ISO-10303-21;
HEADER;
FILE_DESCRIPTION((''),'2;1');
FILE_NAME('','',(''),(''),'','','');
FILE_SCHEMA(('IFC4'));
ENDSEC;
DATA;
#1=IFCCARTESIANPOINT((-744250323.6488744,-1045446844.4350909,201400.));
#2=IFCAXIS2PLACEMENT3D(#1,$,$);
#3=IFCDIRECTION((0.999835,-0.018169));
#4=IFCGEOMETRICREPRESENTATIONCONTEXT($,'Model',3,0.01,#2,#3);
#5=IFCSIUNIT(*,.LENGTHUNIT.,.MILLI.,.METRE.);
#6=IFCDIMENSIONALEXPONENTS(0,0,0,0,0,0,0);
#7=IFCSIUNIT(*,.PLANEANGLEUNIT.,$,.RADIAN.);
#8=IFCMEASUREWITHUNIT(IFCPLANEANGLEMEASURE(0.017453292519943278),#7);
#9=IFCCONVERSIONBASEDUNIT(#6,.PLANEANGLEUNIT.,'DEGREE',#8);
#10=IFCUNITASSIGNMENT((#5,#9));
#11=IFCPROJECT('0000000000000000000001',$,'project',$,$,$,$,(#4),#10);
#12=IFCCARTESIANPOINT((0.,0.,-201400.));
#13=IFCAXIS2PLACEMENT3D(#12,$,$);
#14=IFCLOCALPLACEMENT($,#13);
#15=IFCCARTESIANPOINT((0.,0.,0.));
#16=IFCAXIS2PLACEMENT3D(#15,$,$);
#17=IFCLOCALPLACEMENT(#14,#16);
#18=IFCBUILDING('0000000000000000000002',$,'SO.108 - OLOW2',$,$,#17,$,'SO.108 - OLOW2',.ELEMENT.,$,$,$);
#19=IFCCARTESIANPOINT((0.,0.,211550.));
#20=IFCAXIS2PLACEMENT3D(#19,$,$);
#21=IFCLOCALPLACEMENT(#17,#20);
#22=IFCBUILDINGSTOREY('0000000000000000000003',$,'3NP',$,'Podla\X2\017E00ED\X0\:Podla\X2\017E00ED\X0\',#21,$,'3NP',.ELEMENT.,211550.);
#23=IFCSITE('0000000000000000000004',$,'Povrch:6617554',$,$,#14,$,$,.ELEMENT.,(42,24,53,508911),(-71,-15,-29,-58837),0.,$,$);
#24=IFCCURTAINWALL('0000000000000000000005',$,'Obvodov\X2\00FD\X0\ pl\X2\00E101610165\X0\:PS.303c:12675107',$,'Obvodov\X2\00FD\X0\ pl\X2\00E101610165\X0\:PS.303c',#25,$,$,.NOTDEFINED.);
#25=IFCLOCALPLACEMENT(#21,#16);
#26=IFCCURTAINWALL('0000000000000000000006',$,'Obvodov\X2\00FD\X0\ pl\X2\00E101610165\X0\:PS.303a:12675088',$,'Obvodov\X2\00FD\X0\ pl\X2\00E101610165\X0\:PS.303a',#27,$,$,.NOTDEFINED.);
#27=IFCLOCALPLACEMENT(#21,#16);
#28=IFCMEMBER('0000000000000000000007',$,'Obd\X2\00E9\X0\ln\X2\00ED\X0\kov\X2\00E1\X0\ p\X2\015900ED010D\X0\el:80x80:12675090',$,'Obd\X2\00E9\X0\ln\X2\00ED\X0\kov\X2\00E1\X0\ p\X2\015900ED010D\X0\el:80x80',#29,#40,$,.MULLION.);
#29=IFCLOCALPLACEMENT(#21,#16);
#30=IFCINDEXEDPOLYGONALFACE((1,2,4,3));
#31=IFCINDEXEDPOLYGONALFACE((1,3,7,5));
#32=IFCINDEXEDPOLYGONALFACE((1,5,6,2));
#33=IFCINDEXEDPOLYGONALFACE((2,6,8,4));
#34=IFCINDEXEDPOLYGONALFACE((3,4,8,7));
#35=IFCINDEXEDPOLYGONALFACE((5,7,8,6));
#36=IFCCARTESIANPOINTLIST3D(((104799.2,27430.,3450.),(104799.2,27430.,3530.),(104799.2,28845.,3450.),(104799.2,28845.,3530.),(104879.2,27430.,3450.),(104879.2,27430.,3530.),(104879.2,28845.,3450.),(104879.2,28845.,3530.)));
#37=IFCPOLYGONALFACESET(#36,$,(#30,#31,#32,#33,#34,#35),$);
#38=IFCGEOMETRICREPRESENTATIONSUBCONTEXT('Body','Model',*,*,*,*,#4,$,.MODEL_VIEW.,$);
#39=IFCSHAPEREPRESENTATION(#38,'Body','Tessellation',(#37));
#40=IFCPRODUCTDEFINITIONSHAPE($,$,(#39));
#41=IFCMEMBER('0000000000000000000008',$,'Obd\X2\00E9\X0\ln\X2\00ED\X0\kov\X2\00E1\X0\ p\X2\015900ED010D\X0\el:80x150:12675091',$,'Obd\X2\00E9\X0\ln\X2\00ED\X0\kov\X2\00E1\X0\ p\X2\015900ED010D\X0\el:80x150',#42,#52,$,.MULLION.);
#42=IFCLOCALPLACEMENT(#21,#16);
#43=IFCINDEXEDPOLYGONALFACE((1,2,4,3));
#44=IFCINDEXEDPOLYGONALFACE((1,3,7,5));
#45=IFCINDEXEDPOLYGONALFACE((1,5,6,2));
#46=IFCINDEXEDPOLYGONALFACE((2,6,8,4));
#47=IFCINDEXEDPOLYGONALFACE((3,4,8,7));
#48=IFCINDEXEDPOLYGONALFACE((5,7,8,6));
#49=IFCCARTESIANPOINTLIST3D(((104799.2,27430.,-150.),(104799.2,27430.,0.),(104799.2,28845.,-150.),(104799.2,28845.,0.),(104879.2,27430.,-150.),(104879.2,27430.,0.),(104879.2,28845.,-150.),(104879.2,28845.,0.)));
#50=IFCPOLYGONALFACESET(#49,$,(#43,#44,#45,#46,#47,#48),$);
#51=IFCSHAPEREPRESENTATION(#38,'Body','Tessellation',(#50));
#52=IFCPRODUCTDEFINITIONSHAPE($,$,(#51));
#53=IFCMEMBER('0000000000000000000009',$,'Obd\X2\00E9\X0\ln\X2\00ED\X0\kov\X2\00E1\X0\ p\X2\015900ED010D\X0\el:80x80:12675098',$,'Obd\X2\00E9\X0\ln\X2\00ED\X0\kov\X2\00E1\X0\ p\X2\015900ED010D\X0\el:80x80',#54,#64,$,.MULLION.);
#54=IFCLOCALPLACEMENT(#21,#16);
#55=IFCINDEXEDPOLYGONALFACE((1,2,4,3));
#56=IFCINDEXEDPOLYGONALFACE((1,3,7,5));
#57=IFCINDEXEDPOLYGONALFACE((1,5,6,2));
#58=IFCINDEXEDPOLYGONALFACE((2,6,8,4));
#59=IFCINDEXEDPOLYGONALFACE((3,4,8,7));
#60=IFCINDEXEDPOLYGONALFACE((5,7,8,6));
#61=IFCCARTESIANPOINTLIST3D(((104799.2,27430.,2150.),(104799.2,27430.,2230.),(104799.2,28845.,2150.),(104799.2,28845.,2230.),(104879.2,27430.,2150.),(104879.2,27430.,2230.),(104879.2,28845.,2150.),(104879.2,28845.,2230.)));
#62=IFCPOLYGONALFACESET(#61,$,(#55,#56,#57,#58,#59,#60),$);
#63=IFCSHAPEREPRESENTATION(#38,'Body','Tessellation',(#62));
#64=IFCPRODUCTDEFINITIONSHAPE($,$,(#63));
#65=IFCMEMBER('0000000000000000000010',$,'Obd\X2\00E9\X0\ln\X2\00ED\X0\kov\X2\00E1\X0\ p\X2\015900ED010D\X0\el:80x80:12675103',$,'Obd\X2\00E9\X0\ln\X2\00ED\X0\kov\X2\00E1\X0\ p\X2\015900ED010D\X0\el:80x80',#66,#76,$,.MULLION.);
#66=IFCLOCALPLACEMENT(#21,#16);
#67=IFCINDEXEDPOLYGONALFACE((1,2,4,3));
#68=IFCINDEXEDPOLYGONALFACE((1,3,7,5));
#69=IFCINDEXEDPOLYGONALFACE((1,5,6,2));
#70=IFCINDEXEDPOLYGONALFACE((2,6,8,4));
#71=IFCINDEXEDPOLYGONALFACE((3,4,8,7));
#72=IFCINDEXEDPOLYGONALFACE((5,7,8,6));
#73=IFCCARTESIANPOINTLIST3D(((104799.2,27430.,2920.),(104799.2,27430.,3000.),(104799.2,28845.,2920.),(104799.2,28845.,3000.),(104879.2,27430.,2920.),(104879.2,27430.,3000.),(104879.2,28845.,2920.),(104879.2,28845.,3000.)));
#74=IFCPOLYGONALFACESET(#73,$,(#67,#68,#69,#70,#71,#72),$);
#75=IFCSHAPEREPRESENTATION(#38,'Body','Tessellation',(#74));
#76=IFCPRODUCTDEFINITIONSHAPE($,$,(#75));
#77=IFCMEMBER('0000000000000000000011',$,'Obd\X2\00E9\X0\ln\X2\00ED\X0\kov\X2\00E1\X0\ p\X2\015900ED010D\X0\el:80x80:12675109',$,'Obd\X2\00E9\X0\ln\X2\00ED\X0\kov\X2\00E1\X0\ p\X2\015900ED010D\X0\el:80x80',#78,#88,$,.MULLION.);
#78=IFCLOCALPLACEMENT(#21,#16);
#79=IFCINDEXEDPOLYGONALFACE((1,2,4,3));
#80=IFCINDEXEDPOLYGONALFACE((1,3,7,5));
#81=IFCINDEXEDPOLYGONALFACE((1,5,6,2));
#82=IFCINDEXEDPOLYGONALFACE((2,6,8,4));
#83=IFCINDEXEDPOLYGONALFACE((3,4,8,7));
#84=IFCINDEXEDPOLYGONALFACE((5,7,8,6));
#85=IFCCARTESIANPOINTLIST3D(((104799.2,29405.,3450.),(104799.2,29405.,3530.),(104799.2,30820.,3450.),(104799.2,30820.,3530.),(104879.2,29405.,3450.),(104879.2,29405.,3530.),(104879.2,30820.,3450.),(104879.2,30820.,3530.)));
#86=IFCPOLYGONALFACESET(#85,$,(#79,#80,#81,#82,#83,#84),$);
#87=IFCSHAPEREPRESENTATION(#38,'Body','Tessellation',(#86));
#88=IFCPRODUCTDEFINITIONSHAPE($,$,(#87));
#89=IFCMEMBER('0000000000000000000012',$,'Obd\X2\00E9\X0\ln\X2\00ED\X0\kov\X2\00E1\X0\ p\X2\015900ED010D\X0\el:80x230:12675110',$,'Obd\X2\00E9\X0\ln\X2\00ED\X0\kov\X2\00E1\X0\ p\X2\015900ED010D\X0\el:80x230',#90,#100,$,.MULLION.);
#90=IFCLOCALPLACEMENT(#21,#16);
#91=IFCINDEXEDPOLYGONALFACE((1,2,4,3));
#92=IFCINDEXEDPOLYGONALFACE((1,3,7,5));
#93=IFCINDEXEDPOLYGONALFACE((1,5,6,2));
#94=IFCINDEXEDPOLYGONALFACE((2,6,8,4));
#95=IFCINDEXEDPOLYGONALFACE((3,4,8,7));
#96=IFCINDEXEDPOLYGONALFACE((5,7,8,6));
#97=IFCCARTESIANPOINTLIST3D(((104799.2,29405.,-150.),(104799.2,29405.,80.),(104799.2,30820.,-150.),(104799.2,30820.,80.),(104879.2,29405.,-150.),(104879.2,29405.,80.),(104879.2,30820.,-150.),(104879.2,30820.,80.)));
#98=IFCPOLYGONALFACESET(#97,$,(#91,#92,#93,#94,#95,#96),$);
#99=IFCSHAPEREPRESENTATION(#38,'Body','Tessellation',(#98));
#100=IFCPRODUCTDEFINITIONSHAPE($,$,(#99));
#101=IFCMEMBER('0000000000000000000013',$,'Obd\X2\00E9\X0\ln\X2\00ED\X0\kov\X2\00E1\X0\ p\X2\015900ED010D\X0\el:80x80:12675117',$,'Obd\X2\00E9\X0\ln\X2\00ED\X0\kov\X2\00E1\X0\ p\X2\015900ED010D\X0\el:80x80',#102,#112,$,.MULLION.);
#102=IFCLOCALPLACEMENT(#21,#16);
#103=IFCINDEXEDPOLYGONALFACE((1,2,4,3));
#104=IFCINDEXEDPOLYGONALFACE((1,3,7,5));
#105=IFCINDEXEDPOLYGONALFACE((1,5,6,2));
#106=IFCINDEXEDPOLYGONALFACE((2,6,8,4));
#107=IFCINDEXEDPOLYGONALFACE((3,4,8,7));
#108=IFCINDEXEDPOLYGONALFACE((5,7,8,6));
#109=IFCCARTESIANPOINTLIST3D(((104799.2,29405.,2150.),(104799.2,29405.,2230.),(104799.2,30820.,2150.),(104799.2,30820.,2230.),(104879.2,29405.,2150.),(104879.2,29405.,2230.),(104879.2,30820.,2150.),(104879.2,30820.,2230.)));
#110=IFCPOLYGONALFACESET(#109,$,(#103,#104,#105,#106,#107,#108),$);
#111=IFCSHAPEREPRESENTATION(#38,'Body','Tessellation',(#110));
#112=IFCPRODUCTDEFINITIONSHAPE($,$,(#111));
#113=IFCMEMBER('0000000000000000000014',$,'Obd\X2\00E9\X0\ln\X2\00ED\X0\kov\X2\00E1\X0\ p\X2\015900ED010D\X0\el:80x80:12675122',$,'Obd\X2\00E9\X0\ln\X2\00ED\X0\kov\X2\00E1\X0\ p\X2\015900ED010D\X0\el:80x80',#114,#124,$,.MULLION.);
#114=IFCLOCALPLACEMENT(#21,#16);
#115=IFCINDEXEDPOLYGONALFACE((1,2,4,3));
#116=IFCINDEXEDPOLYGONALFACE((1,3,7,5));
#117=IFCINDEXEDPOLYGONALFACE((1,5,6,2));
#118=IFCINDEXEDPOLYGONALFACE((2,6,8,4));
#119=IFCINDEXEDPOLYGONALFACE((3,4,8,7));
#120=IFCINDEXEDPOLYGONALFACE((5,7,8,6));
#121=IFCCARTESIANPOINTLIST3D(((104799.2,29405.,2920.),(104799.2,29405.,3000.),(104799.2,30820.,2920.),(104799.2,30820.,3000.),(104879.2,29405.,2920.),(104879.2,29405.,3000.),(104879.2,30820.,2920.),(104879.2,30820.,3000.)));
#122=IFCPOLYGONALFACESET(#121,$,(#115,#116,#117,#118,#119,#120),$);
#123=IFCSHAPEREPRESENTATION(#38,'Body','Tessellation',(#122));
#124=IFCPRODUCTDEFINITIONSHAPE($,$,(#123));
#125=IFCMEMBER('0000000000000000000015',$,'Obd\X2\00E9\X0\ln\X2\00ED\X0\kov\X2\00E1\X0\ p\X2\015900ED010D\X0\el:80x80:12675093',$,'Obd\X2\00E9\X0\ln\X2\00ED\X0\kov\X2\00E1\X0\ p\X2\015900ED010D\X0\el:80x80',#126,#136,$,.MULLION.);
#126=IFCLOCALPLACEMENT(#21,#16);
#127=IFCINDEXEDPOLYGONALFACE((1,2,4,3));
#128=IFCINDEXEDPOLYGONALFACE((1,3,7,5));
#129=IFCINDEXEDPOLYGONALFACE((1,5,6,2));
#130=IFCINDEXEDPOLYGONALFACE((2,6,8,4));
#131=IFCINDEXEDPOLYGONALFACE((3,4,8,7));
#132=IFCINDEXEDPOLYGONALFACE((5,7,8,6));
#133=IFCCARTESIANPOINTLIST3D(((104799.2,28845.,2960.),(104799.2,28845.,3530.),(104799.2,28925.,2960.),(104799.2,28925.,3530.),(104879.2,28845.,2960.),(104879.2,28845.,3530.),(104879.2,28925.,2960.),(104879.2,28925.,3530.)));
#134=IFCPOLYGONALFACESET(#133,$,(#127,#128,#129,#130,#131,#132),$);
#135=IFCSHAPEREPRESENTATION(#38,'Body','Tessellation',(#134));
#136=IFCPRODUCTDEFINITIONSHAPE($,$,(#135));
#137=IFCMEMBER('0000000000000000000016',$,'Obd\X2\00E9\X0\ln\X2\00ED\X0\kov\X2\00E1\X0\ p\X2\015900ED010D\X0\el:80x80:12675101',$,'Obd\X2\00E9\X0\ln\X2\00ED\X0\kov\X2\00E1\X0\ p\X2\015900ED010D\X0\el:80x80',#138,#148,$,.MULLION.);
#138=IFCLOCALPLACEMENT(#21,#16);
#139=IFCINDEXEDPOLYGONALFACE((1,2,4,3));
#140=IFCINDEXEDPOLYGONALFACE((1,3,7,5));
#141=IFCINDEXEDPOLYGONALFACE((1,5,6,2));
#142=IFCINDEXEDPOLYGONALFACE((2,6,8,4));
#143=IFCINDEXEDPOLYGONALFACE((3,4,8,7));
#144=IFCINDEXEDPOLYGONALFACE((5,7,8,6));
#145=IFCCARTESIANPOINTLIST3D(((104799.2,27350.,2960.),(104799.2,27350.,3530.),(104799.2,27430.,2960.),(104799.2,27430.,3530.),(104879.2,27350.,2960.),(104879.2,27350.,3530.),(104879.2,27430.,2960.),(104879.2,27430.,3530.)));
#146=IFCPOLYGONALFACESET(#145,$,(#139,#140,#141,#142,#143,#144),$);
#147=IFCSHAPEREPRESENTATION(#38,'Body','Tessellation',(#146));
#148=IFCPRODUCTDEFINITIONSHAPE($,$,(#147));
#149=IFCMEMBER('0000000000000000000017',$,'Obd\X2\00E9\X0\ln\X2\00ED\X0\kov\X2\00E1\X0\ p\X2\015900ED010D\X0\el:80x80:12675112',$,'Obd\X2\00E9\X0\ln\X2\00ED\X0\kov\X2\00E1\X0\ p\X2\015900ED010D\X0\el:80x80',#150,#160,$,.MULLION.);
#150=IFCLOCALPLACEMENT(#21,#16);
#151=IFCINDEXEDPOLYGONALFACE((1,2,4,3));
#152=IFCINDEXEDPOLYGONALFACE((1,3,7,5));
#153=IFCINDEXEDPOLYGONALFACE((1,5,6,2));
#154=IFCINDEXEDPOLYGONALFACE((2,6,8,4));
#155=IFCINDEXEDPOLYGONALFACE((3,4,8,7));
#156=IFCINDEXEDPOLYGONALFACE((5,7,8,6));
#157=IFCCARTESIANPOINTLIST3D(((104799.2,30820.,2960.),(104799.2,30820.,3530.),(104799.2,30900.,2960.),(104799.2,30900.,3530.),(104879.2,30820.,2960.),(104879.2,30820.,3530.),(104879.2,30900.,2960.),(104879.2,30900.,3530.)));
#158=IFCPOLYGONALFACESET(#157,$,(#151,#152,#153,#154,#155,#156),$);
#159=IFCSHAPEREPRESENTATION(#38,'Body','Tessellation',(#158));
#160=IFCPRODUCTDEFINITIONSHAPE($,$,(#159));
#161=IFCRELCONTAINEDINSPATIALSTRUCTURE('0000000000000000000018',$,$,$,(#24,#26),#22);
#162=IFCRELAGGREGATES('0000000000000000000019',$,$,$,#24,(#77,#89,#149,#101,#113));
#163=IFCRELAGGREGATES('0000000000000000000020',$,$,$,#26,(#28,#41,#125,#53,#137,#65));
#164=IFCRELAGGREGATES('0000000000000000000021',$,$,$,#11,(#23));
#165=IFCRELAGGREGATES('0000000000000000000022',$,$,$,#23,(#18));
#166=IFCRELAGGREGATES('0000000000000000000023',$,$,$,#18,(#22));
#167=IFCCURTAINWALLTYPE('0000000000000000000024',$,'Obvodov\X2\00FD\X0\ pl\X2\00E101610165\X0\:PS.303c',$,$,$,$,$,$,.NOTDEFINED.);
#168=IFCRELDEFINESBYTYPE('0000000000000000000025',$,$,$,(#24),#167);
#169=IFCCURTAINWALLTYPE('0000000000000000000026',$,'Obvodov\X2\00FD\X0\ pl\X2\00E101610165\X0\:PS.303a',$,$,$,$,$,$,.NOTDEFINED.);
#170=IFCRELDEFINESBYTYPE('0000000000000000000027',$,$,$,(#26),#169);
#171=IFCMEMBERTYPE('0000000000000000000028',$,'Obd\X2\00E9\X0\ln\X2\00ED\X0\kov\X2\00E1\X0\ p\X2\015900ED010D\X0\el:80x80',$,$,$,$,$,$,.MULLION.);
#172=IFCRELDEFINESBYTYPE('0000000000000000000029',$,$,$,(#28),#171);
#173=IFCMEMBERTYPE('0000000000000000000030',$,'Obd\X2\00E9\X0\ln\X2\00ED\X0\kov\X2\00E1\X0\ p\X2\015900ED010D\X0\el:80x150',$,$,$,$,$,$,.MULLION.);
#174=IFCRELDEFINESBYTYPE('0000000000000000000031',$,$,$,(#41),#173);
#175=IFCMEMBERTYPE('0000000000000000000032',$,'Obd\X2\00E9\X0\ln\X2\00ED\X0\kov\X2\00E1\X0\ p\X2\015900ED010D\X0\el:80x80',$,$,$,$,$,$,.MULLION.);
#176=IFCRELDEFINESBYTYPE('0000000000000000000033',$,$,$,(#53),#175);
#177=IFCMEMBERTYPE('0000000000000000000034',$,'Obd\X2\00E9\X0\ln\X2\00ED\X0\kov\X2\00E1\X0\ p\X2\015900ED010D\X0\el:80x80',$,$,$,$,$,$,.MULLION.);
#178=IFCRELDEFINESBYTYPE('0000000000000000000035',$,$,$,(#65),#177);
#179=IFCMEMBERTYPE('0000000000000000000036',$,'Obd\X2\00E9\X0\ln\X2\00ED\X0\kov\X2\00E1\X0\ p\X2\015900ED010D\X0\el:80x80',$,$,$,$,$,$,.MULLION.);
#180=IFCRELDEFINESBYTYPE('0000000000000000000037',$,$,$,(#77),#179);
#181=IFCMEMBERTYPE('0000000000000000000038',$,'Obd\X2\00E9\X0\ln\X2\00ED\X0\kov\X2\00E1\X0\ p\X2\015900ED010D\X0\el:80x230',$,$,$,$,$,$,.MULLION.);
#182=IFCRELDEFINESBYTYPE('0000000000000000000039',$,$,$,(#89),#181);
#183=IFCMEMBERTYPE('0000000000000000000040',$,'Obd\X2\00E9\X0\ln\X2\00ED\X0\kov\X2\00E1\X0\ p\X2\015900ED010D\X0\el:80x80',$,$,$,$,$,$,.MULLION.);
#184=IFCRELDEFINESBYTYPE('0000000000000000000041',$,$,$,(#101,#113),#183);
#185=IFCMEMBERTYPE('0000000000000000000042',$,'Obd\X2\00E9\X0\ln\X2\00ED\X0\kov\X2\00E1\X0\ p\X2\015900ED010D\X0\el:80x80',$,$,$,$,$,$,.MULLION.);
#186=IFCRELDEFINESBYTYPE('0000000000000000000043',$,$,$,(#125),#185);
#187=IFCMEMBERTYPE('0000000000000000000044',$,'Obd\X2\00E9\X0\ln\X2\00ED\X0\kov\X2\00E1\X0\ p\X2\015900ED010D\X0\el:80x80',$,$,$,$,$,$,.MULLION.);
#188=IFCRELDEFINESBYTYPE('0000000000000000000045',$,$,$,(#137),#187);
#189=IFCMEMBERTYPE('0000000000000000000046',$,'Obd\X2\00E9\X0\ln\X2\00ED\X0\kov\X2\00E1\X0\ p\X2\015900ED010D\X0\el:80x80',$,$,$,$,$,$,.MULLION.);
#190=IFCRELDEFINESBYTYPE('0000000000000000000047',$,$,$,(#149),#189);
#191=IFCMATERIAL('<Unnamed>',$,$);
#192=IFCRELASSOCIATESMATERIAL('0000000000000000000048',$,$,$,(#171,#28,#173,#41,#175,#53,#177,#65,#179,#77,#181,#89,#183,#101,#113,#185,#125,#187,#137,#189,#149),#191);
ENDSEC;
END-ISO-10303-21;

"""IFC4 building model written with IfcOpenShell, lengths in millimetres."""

from ifc_helpers import new_model, entity, si_unit, converted_unit, direction, frame, origin, place, context, subcontext, project, spatial, indexed_curve, outline, extrude, source, transform, mapped, material, type_object, type_shapes, element, aggregate, save


model = new_model("IFC4")

# Units and contexts
model_context = context("Model", 3, precision=0.01, world=frame((-744250323.6488744, -1045446844.4350909, 201400.0)), true_north=direction((0.999835, -0.018169)))
body_context = subcontext(model_context, "Body", "Model", "MODEL_VIEW")
ifc_project = project(units=[si_unit("LENGTHUNIT", "METRE", prefix="MILLI"), converted_unit("PLANEANGLEUNIT", "DEGREE", entity("IfcPlaneAngleMeasure", 0.017453292519943278), si_unit("PLANEANGLEUNIT", "RADIAN"), dimensions=[0, 0, 0, 0, 0, 0, 0])], contexts=[model_context])

# Site, building, storey
site_placement = place(None, frame((0.0, 0.0, -201400.0)))
site = spatial("IfcSite", under=ifc_project, at=site_placement, Name="Povrch:6617554", CompositionType="ELEMENT", RefLatitude=(42, 24, 53, 508911), RefLongitude=(-71, -15, -29, -58837), RefElevation=0.0)
building_placement = place(site_placement, origin())
building = spatial("IfcBuilding", under=site, at=building_placement, Name="SO.108 - OLOW2", LongName="SO.108 - OLOW2", CompositionType="ELEMENT")
storey_placement = place(building_placement, frame((0.0, 0.0, 211550.0)))
storey = spatial("IfcBuildingStorey", under=building, at=storey_placement, Name="3NP", ObjectType="Podlaží:Podlaží", LongName="3NP", CompositionType="ELEMENT", Elevation=211550.0)

# Shared definitions
ifc_material_1 = material(Name="<Unnamed>")

# Curtain wall
curtain_wall_type_1 = type_object("IfcCurtainWallType", Name="Obvodový plášť:PS.303c", PredefinedType="NOTDEFINED")
curtain_wall_1_placement = place(storey_placement, frame((0.0, 0.0, -211550.0)))
curtain_wall_1 = element("IfcCurtainWall", 1, at=curtain_wall_1_placement, inside=storey, type_object=curtain_wall_type_1, Name="Obvodový plášť:PS.303c:12675107", ObjectType="Obvodový plášť:PS.303c", PredefinedType="NOTDEFINED")

# Curtain wall, members
curtain_wall_type_2 = type_object("IfcCurtainWallType", Name="Obvodový plášť:PS.303a", PredefinedType="NOTDEFINED")
curtain_wall_2_placement = place(storey_placement, frame((0.0, 0.0, -211550.0)))
curtain_wall_2 = element("IfcCurtainWall", 2, at=curtain_wall_2_placement, inside=storey, type_object=curtain_wall_type_2, Name="Obvodový plášť:PS.303a:12675088", ObjectType="Obvodový plášť:PS.303a", PredefinedType="NOTDEFINED")
member_type_1 = type_object("IfcMemberType", Name="Obdélníková příčel:80x80", PredefinedType="MULLION", material=ifc_material_1)
shared_shape_1 = source(origin(), body_context, "Body", "SweptSolid", [
    extrude(outline(indexed_curve([(-40.0, -40.0), (40.0, -40.0), (40.0, 40.0), (-40.0, 40.0), (-40.0, -40.0)], self_intersect=False)), frame((-40.0, 0.0, -1415.0), z_axis=(0.0, 0.0, 1.0), x_axis=(-1.0, 0.0, 0.0)), (0.0, 0.0, 1.0), 1415.0),
])
type_shapes(member_type_1, [shared_shape_1])
member_1_placement = place(curtain_wall_2_placement, frame((104839.2, 27430.0, 215080.0), z_axis=(0.0, -1.0, 0.0), x_axis=(0.0, 0.0, 1.0)))
member_1 = element("IfcMember", 3, at=member_1_placement, type_object=member_type_1, material=ifc_material_1, Name="Obdélníková příčel:80x80:12675090", ObjectType="Obdélníková příčel:80x80", PredefinedType="MULLION", context=body_context, shape_type="MappedRepresentation", body=[
    mapped(shared_shape_1, transform((0.0, 0.0, 0.0), scale=1.0)),
])
member_type_2 = type_object("IfcMemberType", Name="Obdélníková příčel:80x150", PredefinedType="MULLION", material=ifc_material_1)
shared_shape_2 = source(origin(), body_context, "Body", "SweptSolid", [
    extrude(outline(indexed_curve([(-75.0, -40.0), (75.0, -40.0), (75.0, 40.0), (-75.0, 40.0), (-75.0, -40.0)], self_intersect=False)), frame((-75.0, 0.0, -1415.0), z_axis=(0.0, 0.0, 1.0), x_axis=(-1.0, 0.0, 0.0)), (0.0, 0.0, 1.0), 1415.0),
])
type_shapes(member_type_2, [shared_shape_2])
member_2_placement = place(curtain_wall_2_placement, frame((104839.2, 28845.0, 211400.0), z_axis=(0.0, 1.0, 0.0), x_axis=(0.0, 0.0, -1.0)))
member_2 = element("IfcMember", 4, at=member_2_placement, type_object=member_type_2, material=ifc_material_1, Name="Obdélníková příčel:80x150:12675091", ObjectType="Obdélníková příčel:80x150", PredefinedType="MULLION", context=body_context, shape_type="MappedRepresentation", body=[
    mapped(shared_shape_2, transform((0.0, 0.0, 0.0), scale=1.0)),
])
member_type_3 = type_object("IfcMemberType", Name="Obdélníková příčel:80x80", PredefinedType="MULLION", material=ifc_material_1)
shared_shape_3 = source(origin(), body_context, "Body", "SweptSolid", [
    extrude(outline(indexed_curve([(-40.0, -40.0), (40.0, -40.0), (40.0, 40.0), (-40.0, 40.0), (-40.0, -40.0)], self_intersect=False)), frame((0.0, 0.0, -1415.0), z_axis=(0.0, 0.0, 1.0), x_axis=(-1.0, 0.0, 0.0)), (0.0, 0.0, 1.0), 1415.0),
])
type_shapes(member_type_3, [shared_shape_3])
member_3_placement = place(curtain_wall_2_placement, frame((104839.2, 27430.0, 213740.0), z_axis=(0.0, -1.0, 0.0), x_axis=(0.0, 0.0, 1.0)))
member_3 = element("IfcMember", 5, at=member_3_placement, type_object=member_type_3, material=ifc_material_1, Name="Obdélníková příčel:80x80:12675098", ObjectType="Obdélníková příčel:80x80", PredefinedType="MULLION", context=body_context, shape_type="MappedRepresentation", body=[
    mapped(shared_shape_3, transform((0.0, 0.0, 0.0), scale=1.0)),
])
member_type_4 = type_object("IfcMemberType", Name="Obdélníková příčel:80x80", PredefinedType="MULLION", material=ifc_material_1)
shared_shape_4 = source(origin(), body_context, "Body", "SweptSolid", [
    extrude(outline(indexed_curve([(-40.0, -40.0), (40.0, -40.0), (40.0, 40.0), (-40.0, 40.0), (-40.0, -40.0)], self_intersect=False)), frame((0.0, 0.0, -1415.0), z_axis=(0.0, 0.0, 1.0), x_axis=(-1.0, 0.0, 0.0)), (0.0, 0.0, 1.0), 1415.0),
])
type_shapes(member_type_4, [shared_shape_4])
member_4_placement = place(curtain_wall_2_placement, frame((104839.2, 27430.0, 214510.0), z_axis=(0.0, -1.0, 0.0), x_axis=(0.0, 0.0, 1.0)))
member_4 = element("IfcMember", 6, at=member_4_placement, type_object=member_type_4, material=ifc_material_1, Name="Obdélníková příčel:80x80:12675103", ObjectType="Obdélníková příčel:80x80", PredefinedType="MULLION", context=body_context, shape_type="MappedRepresentation", body=[
    mapped(shared_shape_4, transform((0.0, 0.0, 0.0), scale=1.0)),
])

# Members
member_type_5 = type_object("IfcMemberType", Name="Obdélníková příčel:80x80", PredefinedType="MULLION", material=ifc_material_1)
shared_shape_5 = source(origin(), body_context, "Body", "SweptSolid", [
    extrude(outline(indexed_curve([(-40.0, -40.0), (40.0, -40.0), (40.0, 40.0), (-40.0, 40.0), (-40.0, -40.0)], self_intersect=False)), frame((-40.0, 0.0, -1415.0), z_axis=(0.0, 0.0, 1.0), x_axis=(-1.0, 0.0, 0.0)), (0.0, 0.0, 1.0), 1415.0),
])
type_shapes(member_type_5, [shared_shape_5])
member_5_placement = place(curtain_wall_1_placement, frame((104839.2, 29405.0, 215080.0), z_axis=(0.0, -1.0, 0.0), x_axis=(0.0, 0.0, 1.0)))
member_5 = element("IfcMember", 7, at=member_5_placement, type_object=member_type_5, material=ifc_material_1, Name="Obdélníková příčel:80x80:12675109", ObjectType="Obdélníková příčel:80x80", PredefinedType="MULLION", context=body_context, shape_type="MappedRepresentation", body=[
    mapped(shared_shape_5, transform((0.0, 0.0, 0.0), scale=1.0)),
])
member_type_6 = type_object("IfcMemberType", Name="Obdélníková příčel:80x230", PredefinedType="MULLION", material=ifc_material_1)
shared_shape_6 = source(origin(), body_context, "Body", "SweptSolid", [
    extrude(outline(indexed_curve([(-115.0, -40.0), (115.0, -40.0), (115.0, 40.0), (-115.0, 40.0), (-115.0, -40.0)], self_intersect=False)), frame((-115.0, 0.0, -1415.0), z_axis=(0.0, 0.0, 1.0), x_axis=(-1.0, 0.0, 0.0)), (0.0, 0.0, 1.0), 1415.0),
])
type_shapes(member_type_6, [shared_shape_6])
member_6_placement = place(curtain_wall_1_placement, frame((104839.2, 30820.0, 211400.0), z_axis=(0.0, 1.0, 0.0), x_axis=(0.0, 0.0, -1.0)))
member_6 = element("IfcMember", 8, at=member_6_placement, type_object=member_type_6, material=ifc_material_1, Name="Obdélníková příčel:80x230:12675110", ObjectType="Obdélníková příčel:80x230", PredefinedType="MULLION", context=body_context, shape_type="MappedRepresentation", body=[
    mapped(shared_shape_6, transform((0.0, 0.0, 0.0), scale=1.0)),
])
member_type_7 = type_object("IfcMemberType", Name="Obdélníková příčel:80x80", PredefinedType="MULLION", material=ifc_material_1)
shared_shape_7 = source(origin(), body_context, "Body", "SweptSolid", [
    extrude(outline(indexed_curve([(-40.0, -40.0), (40.0, -40.0), (40.0, 40.0), (-40.0, 40.0), (-40.0, -40.0)], self_intersect=False)), frame((0.0, 0.0, -1415.0), z_axis=(0.0, 0.0, 1.0), x_axis=(-1.0, 0.0, 0.0)), (0.0, 0.0, 1.0), 1415.0),
])
type_shapes(member_type_7, [shared_shape_7])
member_7_placement = place(curtain_wall_1_placement, frame((104839.2, 29405.0, 213740.0), z_axis=(0.0, -1.0, 0.0), x_axis=(0.0, 0.0, 1.0)))
member_7 = element("IfcMember", 9, at=member_7_placement, type_object=member_type_7, material=ifc_material_1, Name="Obdélníková příčel:80x80:12675117", ObjectType="Obdélníková příčel:80x80", PredefinedType="MULLION", context=body_context, shape_type="MappedRepresentation", body=[
    mapped(shared_shape_7, transform((0.0, 0.0, 0.0), scale=1.0)),
])
member_8_placement = place(curtain_wall_1_placement, frame((104839.2, 29405.0, 214510.0), z_axis=(0.0, -1.0, 0.0), x_axis=(0.0, 0.0, 1.0)))
member_8 = element("IfcMember", 10, at=member_8_placement, type_object=member_type_7, material=ifc_material_1, Name="Obdélníková příčel:80x80:12675122", ObjectType="Obdélníková příčel:80x80", PredefinedType="MULLION", context=body_context, shape_type="MappedRepresentation", body=[
    mapped(shared_shape_7, transform((0.0, 0.0, 0.0), scale=1.0)),
])
member_type_8 = type_object("IfcMemberType", Name="Obdélníková příčel:80x80", PredefinedType="MULLION", material=ifc_material_1)
shared_shape_8 = source(origin(), body_context, "Body", "SweptSolid", [
    extrude(outline(indexed_curve([(-40.0, -40.0), (40.0, -40.0), (40.0, 40.0), (-40.0, 40.0), (-40.0, -40.0)], self_intersect=False)), frame((-40.0, 0.0, -570.0), z_axis=(0.0, 0.0, 1.0), x_axis=(-1.0, 0.0, 0.0)), (0.0, 0.0, 1.0), 570.0),
])
type_shapes(member_type_8, [shared_shape_8])
member_9_placement = place(curtain_wall_2_placement, frame((104839.2, 28925.0, 215080.0), z_axis=(0.0, 0.0, 1.0), x_axis=(0.0, 1.0, 0.0)))
member_9 = element("IfcMember", 11, at=member_9_placement, type_object=member_type_8, material=ifc_material_1, Name="Obdélníková příčel:80x80:12675093", ObjectType="Obdélníková příčel:80x80", PredefinedType="MULLION", context=body_context, shape_type="MappedRepresentation", body=[
    mapped(shared_shape_8, transform((0.0, 0.0, 0.0), scale=1.0)),
])
member_type_9 = type_object("IfcMemberType", Name="Obdélníková příčel:80x80", PredefinedType="MULLION", material=ifc_material_1)
shared_shape_9 = source(origin(), body_context, "Body", "SweptSolid", [
    extrude(outline(indexed_curve([(-40.0, -40.0), (40.0, -40.0), (40.0, 40.0), (-40.0, 40.0), (-40.0, -40.0)], self_intersect=False)), frame((-40.0, 0.0, -570.0), z_axis=(0.0, 0.0, 1.0), x_axis=(-1.0, 0.0, 0.0)), (0.0, 0.0, 1.0), 570.0),
])
type_shapes(member_type_9, [shared_shape_9])
member_10_placement = place(curtain_wall_2_placement, frame((104839.2, 27350.0, 214510.0), z_axis=(0.0, 0.0, -1.0), x_axis=(0.0, -1.0, 0.0)))
member_10 = element("IfcMember", 12, at=member_10_placement, type_object=member_type_9, material=ifc_material_1, Name="Obdélníková příčel:80x80:12675101", ObjectType="Obdélníková příčel:80x80", PredefinedType="MULLION", context=body_context, shape_type="MappedRepresentation", body=[
    mapped(shared_shape_9, transform((0.0, 0.0, 0.0), scale=1.0)),
])
member_type_10 = type_object("IfcMemberType", Name="Obdélníková příčel:80x80", PredefinedType="MULLION", material=ifc_material_1)
shared_shape_10 = source(origin(), body_context, "Body", "SweptSolid", [
    extrude(outline(indexed_curve([(-40.0, -40.0), (40.0, -40.0), (40.0, 40.0), (-40.0, 40.0), (-40.0, -40.0)], self_intersect=False)), frame((-40.0, 0.0, -570.0), z_axis=(0.0, 0.0, 1.0), x_axis=(-1.0, 0.0, 0.0)), (0.0, 0.0, 1.0), 570.0),
])
type_shapes(member_type_10, [shared_shape_10])
member_11_placement = place(curtain_wall_1_placement, frame((104839.2, 30900.0, 215080.0), z_axis=(0.0, 0.0, 1.0), x_axis=(0.0, 1.0, 0.0)))
member_11 = element("IfcMember", 13, at=member_11_placement, type_object=member_type_10, material=ifc_material_1, Name="Obdélníková příčel:80x80:12675112", ObjectType="Obdélníková příčel:80x80", PredefinedType="MULLION", context=body_context, shape_type="MappedRepresentation", body=[
    mapped(shared_shape_10, transform((0.0, 0.0, 0.0), scale=1.0)),
])

aggregate(curtain_wall_1, [member_5, member_6, member_11, member_7, member_8])

aggregate(curtain_wall_2, [member_1, member_2, member_9, member_3, member_10, member_4])

save(model, "model.ifc")
